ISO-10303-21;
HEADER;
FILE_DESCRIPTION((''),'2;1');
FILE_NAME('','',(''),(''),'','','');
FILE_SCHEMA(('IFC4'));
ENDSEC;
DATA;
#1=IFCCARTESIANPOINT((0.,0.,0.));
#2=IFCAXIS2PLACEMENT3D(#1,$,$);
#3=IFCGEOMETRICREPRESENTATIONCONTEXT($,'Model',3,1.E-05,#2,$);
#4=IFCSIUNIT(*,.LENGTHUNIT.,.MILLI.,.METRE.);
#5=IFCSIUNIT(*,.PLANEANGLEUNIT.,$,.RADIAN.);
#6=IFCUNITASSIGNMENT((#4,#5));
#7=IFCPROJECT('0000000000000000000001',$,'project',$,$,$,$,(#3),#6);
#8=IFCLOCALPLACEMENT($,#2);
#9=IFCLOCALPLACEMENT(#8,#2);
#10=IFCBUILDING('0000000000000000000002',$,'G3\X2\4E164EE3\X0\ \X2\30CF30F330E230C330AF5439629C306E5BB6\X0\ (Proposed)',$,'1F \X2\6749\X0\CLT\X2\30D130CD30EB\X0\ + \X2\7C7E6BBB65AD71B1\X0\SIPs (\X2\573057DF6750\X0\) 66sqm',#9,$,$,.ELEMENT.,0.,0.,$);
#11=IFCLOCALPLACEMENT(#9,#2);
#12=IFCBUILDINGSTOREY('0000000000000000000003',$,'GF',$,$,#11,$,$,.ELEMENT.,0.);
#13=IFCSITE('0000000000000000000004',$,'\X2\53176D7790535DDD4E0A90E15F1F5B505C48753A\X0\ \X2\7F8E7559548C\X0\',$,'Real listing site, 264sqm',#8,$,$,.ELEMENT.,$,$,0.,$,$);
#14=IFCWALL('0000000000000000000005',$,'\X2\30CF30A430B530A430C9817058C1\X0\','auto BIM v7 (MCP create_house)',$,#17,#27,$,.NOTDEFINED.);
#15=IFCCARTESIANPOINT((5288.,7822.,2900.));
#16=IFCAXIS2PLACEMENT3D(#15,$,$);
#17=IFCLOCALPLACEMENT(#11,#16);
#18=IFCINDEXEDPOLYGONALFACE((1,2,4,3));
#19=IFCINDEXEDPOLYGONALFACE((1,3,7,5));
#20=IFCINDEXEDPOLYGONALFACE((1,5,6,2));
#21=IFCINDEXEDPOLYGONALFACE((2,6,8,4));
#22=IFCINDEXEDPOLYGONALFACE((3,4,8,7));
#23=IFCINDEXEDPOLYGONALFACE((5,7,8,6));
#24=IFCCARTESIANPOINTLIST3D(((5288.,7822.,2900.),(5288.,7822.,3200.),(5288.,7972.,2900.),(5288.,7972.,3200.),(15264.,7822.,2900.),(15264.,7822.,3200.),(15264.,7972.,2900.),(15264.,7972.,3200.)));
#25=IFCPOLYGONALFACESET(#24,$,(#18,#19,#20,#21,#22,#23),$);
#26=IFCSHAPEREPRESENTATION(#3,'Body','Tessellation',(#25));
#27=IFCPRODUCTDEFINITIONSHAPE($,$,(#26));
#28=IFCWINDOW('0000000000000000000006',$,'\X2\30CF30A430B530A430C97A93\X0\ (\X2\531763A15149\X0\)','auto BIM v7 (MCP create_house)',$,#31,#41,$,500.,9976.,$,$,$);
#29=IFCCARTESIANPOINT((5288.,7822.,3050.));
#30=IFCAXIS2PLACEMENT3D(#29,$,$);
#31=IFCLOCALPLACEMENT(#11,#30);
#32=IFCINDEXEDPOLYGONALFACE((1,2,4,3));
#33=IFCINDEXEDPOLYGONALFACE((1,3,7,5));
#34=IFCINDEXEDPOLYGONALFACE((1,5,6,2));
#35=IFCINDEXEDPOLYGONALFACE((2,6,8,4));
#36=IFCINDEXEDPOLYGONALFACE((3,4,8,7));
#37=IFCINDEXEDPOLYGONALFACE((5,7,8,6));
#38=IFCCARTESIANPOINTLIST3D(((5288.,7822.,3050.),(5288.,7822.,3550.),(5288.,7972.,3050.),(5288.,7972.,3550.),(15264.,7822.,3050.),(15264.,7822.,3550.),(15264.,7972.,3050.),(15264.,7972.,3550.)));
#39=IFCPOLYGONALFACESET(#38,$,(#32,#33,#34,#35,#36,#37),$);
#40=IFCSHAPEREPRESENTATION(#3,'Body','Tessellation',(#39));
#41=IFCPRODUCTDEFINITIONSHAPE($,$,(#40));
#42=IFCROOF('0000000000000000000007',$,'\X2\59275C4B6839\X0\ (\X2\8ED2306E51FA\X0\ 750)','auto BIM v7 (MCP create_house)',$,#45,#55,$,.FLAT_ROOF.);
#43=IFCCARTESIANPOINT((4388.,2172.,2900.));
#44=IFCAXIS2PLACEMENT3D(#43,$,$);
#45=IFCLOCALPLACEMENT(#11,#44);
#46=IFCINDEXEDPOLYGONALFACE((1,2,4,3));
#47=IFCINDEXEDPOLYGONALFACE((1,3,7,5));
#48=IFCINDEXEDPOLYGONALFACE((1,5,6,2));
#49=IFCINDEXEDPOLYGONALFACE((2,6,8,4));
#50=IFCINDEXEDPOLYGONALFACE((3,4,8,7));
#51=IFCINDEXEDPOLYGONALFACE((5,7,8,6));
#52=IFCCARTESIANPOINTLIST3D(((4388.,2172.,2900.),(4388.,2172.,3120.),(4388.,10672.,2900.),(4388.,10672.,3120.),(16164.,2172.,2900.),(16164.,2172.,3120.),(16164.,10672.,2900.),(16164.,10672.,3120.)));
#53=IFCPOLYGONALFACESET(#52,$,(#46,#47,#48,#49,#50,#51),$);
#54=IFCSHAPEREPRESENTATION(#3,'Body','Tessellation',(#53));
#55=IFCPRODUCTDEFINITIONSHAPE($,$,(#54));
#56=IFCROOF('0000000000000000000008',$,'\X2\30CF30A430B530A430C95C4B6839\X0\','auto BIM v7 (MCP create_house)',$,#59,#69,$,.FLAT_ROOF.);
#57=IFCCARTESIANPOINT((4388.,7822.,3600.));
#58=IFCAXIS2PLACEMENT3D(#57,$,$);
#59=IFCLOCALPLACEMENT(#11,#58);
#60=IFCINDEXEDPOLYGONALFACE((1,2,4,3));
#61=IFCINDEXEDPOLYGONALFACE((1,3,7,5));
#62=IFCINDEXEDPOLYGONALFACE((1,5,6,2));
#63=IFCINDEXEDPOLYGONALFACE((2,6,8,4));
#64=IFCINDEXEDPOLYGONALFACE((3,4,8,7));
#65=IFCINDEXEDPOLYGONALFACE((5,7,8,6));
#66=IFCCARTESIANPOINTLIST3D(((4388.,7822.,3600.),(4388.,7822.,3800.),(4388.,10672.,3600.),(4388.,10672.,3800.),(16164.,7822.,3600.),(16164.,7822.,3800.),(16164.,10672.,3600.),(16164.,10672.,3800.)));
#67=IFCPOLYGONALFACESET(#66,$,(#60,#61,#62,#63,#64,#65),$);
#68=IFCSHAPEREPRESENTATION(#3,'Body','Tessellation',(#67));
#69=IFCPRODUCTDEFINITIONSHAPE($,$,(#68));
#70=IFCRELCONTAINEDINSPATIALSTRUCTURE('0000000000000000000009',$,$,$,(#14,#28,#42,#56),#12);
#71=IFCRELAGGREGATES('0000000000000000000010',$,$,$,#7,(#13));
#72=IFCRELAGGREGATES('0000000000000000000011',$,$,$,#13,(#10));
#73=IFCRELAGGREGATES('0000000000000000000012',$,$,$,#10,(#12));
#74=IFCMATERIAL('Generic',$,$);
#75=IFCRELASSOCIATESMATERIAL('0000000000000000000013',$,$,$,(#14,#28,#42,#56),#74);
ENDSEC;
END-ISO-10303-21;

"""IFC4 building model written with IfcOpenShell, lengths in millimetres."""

from ifc_helpers import new_model, si_unit, frame, frame_2d, origin, place, context, project, spatial, rectangle, extrude, material, element, fill, save


model = new_model("IFC4")

# Units and contexts
model_context = context("Model", 3, precision=1e-05, world=origin())
ifc_project = project(units=[si_unit("LENGTHUNIT", "METRE", prefix="MILLI"), si_unit("PLANEANGLEUNIT", "RADIAN")], contexts=[model_context])

# Site, building, storey
site_placement = place(None, origin())
site = spatial("IfcSite", under=ifc_project, at=site_placement, Name="北海道川上郡弟子屈町 美留和", ObjectType="Real listing site, 264sqm", CompositionType="ELEMENT", RefElevation=0.0)
building_placement = place(site_placement, origin())
building = spatial("IfcBuilding", under=site, at=building_placement, Name="G3世代 ハンモック吹抜の家 (Proposed)", ObjectType="1F 杉CLTパネル + 籾殻断熱SIPs (地域材) 66sqm", CompositionType="ELEMENT", ElevationOfRefHeight=0.0, ElevationOfTerrain=0.0)
storey_placement = place(building_placement, origin())
storey = spatial("IfcBuildingStorey", under=building, at=storey_placement, Name="GF", CompositionType="ELEMENT", Elevation=0.0)

# Shared definitions
ifc_material = material(Name="Generic")

# Wall, opening, window
wall_1_placement = place(storey_placement, frame((5288.0, 7822.0, 2900.0)))
wall_1 = element("IfcWall", 1, at=wall_1_placement, inside=storey, material=ifc_material, Name="ハイサイド腰壁", Description="auto BIM v7 (MCP create_house)", PredefinedType="NOTDEFINED", context=model_context, shape_type="SweptSolid", body=[
    extrude(rectangle(XDim=9976.0, YDim=150.0, at=frame_2d((4988.0, 75.0))), frame((5288.0, 7822.0, 2900.0)), (0.0, 0.0, 1.0), 700.0),
])
opening_1_placement = place(storey_placement, frame((5288.0, 7822.0, 3050.0)))
opening_1 = element("IfcOpeningElement", 2, at=opening_1_placement, cuts=wall_1, PredefinedType="NOTDEFINED", context=model_context, shape_type="SweptSolid", body=[
    extrude(rectangle(XDim=9976.0, YDim=150.0, at=frame_2d((4988.0, 75.0))), frame((5288.0, 7822.0, 3050.0)), (0.0, 0.0, 1.0), 500.0),
])
window_1_placement = place(storey_placement, frame((5288.0, 7822.0, 3050.0)))
window_1 = element("IfcWindow", 3, at=window_1_placement, inside=storey, material=ifc_material, Name="ハイサイド窓 (北採光)", Description="auto BIM v7 (MCP create_house)", OverallHeight=500.0, OverallWidth=9976.0, context=model_context, shape_type="SweptSolid", body=[
    extrude(rectangle(XDim=9976.0, YDim=150.0, at=frame_2d((4988.0, 75.0))), frame((5288.0, 7822.0, 3050.0)), (0.0, 0.0, 1.0), 500.0),
])
fill(opening_1, window_1)

# Roofs
roof_1_placement = place(storey_placement, frame((4388.0, 2172.0, 2900.0)))
element("IfcRoof", 4, at=roof_1_placement, inside=storey, material=ifc_material, Name="大屋根 (軒の出 750)", Description="auto BIM v7 (MCP create_house)", PredefinedType="FLAT_ROOF", context=model_context, shape_type="SweptSolid", body=[
    extrude(rectangle(XDim=11776.0, YDim=8500.0, at=frame_2d((5888.0, 4250.0))), frame((4388.0, 2172.0, 2900.0)), (0.0, 0.0, 1.0), 220.0),
])
roof_2_placement = place(storey_placement, frame((4388.0, 7822.0, 3600.0)))
element("IfcRoof", 5, at=roof_2_placement, inside=storey, material=ifc_material, Name="ハイサイド屋根", Description="auto BIM v7 (MCP create_house)", PredefinedType="FLAT_ROOF", context=model_context, shape_type="SweptSolid", body=[
    extrude(rectangle(XDim=11776.0, YDim=2850.0, at=frame_2d((5888.0, 1425.0))), frame((4388.0, 7822.0, 3600.0)), (0.0, 0.0, 1.0), 200.0),
])

save(model, "model.ifc")
